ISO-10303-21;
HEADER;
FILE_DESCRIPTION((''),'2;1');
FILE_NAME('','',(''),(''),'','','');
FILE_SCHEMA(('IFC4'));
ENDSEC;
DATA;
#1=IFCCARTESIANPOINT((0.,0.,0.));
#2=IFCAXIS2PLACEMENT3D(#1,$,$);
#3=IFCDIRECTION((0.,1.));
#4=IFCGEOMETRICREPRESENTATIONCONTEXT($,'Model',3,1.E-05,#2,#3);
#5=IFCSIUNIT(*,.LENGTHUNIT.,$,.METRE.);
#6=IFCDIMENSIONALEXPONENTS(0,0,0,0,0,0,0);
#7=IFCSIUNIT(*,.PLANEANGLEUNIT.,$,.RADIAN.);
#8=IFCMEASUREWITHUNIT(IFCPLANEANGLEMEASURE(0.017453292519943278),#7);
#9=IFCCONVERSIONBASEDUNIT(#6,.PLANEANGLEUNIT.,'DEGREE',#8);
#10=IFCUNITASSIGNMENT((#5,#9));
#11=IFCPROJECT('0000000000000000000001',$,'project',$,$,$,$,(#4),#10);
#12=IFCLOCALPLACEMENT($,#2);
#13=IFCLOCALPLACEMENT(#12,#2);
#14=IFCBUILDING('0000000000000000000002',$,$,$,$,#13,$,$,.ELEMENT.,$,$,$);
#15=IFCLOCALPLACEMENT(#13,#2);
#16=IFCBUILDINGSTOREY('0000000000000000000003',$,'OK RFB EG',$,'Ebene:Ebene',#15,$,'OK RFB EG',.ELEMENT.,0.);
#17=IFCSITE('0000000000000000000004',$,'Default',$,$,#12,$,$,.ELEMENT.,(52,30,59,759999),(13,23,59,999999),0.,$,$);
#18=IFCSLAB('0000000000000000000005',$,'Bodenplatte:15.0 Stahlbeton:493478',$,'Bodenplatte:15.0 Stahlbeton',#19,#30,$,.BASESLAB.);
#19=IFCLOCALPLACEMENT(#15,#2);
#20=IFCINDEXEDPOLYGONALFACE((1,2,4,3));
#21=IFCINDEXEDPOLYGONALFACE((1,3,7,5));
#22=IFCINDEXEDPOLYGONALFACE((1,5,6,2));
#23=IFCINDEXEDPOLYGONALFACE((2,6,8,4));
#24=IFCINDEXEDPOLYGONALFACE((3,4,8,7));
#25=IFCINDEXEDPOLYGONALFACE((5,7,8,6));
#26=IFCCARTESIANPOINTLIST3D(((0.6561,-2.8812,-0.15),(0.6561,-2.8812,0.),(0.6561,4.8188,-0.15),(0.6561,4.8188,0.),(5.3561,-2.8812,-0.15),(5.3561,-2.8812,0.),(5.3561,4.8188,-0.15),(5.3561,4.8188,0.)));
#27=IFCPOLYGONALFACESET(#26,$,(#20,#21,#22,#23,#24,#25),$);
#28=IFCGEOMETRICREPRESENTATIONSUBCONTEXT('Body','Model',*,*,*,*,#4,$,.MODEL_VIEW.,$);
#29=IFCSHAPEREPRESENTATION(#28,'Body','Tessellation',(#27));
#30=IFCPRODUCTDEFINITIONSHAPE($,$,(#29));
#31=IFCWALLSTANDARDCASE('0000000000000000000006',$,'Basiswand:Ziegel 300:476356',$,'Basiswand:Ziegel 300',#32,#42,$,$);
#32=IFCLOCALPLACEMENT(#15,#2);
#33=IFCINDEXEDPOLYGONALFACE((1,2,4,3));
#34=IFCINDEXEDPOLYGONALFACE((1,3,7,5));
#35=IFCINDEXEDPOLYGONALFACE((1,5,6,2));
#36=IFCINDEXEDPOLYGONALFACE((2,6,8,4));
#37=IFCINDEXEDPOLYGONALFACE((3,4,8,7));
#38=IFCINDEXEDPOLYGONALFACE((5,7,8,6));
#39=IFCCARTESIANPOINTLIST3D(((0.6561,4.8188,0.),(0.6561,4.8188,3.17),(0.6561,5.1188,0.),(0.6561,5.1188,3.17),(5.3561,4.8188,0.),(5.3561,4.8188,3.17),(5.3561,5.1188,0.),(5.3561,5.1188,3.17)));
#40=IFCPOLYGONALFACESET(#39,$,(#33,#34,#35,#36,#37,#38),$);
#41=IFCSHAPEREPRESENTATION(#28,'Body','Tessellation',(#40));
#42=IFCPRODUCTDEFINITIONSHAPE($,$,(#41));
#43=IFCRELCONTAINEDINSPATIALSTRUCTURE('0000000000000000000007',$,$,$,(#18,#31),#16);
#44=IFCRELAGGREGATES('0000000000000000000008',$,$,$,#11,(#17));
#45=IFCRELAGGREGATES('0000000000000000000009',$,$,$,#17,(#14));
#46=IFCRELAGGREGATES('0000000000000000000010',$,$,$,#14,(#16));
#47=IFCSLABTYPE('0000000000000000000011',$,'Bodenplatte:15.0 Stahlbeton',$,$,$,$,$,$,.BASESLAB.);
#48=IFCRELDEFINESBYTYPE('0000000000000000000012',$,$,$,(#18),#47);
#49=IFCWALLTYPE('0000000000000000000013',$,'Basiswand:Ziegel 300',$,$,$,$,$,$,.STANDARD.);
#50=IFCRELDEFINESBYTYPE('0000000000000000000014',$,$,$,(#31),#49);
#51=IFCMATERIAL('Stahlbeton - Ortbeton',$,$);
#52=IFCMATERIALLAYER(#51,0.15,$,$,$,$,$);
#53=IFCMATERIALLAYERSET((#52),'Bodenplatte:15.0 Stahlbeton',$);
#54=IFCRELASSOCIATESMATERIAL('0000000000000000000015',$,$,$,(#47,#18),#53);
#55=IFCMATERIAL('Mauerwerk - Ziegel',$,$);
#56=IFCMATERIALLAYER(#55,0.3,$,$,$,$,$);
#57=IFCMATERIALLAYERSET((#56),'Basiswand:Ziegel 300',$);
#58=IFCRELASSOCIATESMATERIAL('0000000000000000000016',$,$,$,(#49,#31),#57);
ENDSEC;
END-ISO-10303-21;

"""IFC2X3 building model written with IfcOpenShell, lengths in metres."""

from ifc_helpers import new_model, entity, si_unit, converted_unit, direction, frame, frame_2d, origin, place, context, subcontext, project, spatial, rectangle, extrude, material, layer, layer_set, layer_usage, type_object, element, save


model = new_model("IFC2X3")

# Units and contexts
model_context = context("Model", 3, precision=1e-05, world=origin(), true_north=direction((0.0, 1.0)))
body_context = subcontext(model_context, "Body", "Model", "MODEL_VIEW")
ifc_project = project(units=[si_unit("LENGTHUNIT", "METRE"), converted_unit("PLANEANGLEUNIT", "DEGREE", entity("IfcPlaneAngleMeasure", 0.017453292519943278), si_unit("PLANEANGLEUNIT", "RADIAN"), dimensions=[0, 0, 0, 0, 0, 0, 0])], contexts=[model_context])

# Site, building, storey
site_placement = place(None, origin())
site = spatial("IfcSite", under=ifc_project, at=site_placement, Name="Default", CompositionType="ELEMENT", RefLatitude=(52, 30, 59, 759999), RefLongitude=(13, 23, 59, 999999), RefElevation=0.0)
building_placement = place(site_placement, origin())
building = spatial("IfcBuilding", under=site, at=building_placement, CompositionType="ELEMENT")
storey_placement = place(building_placement, origin())
storey = spatial("IfcBuildingStorey", under=building, at=storey_placement, Name="OK RFB EG", ObjectType="Ebene:Ebene", LongName="OK RFB EG", CompositionType="ELEMENT", Elevation=0.0)

# Slab
ifc_material_1 = material(Name="Stahlbeton - Ortbeton")
ifc_layer_1 = layer(ifc_material_1, 0.15)
ifc_layer_set_1 = layer_set([ifc_layer_1], Name="Bodenplatte:15.0 Stahlbeton")
ifc_layer_usage_1 = layer_usage(ifc_layer_set_1, "AXIS3", "POSITIVE", 0.0)
slab_type = type_object("IfcSlabType", Name="Bodenplatte:15.0 Stahlbeton", PredefinedType="BASESLAB", material=ifc_layer_set_1)
slab_placement = place(storey_placement, origin())
element("IfcSlab", 1, at=slab_placement, inside=storey, type_object=slab_type, material=ifc_layer_usage_1, Name="Bodenplatte:15.0 Stahlbeton:493478", ObjectType="Bodenplatte:15.0 Stahlbeton", PredefinedType="BASESLAB", context=body_context, shape_type="SweptSolid", body=[
    extrude(rectangle(XDim=7.7, YDim=4.7, at=frame_2d((0.0, 0.0), x_axis=(1.0, 0.0))), frame((3.0061, 0.9688, 0.0), z_axis=(0.0, 0.0, -1.0), x_axis=(0.0, 1.0, 0.0)), (0.0, 0.0, 1.0), 0.15),
])

# Wall
ifc_material_2 = material(Name="Mauerwerk - Ziegel")
ifc_layer_2 = layer(ifc_material_2, 0.3)
ifc_layer_set_2 = layer_set([ifc_layer_2], Name="Basiswand:Ziegel 300")
ifc_layer_usage_2 = layer_usage(ifc_layer_set_2, "AXIS2", "NEGATIVE", 0.15)
wall_type = type_object("IfcWallType", Name="Basiswand:Ziegel 300", PredefinedType="STANDARD", material=ifc_layer_set_2)
wall_placement = place(storey_placement, frame((5.3561, 4.9688, 0.0), z_axis=(0.0, 0.0, 1.0), x_axis=(-1.0, 0.0, 0.0)))
element("IfcWallStandardCase", 2, at=wall_placement, inside=storey, type_object=wall_type, material=ifc_layer_usage_2, Name="Basiswand:Ziegel 300:476356", ObjectType="Basiswand:Ziegel 300", context=body_context, shape_type="SweptSolid", body=[
    extrude(rectangle(XDim=4.7, YDim=0.3, at=frame_2d((2.35, 0.0), x_axis=(-1.0, 0.0))), origin(), (0.0, 0.0, 1.0), 3.17),
])

save(model, "model.ifc")
